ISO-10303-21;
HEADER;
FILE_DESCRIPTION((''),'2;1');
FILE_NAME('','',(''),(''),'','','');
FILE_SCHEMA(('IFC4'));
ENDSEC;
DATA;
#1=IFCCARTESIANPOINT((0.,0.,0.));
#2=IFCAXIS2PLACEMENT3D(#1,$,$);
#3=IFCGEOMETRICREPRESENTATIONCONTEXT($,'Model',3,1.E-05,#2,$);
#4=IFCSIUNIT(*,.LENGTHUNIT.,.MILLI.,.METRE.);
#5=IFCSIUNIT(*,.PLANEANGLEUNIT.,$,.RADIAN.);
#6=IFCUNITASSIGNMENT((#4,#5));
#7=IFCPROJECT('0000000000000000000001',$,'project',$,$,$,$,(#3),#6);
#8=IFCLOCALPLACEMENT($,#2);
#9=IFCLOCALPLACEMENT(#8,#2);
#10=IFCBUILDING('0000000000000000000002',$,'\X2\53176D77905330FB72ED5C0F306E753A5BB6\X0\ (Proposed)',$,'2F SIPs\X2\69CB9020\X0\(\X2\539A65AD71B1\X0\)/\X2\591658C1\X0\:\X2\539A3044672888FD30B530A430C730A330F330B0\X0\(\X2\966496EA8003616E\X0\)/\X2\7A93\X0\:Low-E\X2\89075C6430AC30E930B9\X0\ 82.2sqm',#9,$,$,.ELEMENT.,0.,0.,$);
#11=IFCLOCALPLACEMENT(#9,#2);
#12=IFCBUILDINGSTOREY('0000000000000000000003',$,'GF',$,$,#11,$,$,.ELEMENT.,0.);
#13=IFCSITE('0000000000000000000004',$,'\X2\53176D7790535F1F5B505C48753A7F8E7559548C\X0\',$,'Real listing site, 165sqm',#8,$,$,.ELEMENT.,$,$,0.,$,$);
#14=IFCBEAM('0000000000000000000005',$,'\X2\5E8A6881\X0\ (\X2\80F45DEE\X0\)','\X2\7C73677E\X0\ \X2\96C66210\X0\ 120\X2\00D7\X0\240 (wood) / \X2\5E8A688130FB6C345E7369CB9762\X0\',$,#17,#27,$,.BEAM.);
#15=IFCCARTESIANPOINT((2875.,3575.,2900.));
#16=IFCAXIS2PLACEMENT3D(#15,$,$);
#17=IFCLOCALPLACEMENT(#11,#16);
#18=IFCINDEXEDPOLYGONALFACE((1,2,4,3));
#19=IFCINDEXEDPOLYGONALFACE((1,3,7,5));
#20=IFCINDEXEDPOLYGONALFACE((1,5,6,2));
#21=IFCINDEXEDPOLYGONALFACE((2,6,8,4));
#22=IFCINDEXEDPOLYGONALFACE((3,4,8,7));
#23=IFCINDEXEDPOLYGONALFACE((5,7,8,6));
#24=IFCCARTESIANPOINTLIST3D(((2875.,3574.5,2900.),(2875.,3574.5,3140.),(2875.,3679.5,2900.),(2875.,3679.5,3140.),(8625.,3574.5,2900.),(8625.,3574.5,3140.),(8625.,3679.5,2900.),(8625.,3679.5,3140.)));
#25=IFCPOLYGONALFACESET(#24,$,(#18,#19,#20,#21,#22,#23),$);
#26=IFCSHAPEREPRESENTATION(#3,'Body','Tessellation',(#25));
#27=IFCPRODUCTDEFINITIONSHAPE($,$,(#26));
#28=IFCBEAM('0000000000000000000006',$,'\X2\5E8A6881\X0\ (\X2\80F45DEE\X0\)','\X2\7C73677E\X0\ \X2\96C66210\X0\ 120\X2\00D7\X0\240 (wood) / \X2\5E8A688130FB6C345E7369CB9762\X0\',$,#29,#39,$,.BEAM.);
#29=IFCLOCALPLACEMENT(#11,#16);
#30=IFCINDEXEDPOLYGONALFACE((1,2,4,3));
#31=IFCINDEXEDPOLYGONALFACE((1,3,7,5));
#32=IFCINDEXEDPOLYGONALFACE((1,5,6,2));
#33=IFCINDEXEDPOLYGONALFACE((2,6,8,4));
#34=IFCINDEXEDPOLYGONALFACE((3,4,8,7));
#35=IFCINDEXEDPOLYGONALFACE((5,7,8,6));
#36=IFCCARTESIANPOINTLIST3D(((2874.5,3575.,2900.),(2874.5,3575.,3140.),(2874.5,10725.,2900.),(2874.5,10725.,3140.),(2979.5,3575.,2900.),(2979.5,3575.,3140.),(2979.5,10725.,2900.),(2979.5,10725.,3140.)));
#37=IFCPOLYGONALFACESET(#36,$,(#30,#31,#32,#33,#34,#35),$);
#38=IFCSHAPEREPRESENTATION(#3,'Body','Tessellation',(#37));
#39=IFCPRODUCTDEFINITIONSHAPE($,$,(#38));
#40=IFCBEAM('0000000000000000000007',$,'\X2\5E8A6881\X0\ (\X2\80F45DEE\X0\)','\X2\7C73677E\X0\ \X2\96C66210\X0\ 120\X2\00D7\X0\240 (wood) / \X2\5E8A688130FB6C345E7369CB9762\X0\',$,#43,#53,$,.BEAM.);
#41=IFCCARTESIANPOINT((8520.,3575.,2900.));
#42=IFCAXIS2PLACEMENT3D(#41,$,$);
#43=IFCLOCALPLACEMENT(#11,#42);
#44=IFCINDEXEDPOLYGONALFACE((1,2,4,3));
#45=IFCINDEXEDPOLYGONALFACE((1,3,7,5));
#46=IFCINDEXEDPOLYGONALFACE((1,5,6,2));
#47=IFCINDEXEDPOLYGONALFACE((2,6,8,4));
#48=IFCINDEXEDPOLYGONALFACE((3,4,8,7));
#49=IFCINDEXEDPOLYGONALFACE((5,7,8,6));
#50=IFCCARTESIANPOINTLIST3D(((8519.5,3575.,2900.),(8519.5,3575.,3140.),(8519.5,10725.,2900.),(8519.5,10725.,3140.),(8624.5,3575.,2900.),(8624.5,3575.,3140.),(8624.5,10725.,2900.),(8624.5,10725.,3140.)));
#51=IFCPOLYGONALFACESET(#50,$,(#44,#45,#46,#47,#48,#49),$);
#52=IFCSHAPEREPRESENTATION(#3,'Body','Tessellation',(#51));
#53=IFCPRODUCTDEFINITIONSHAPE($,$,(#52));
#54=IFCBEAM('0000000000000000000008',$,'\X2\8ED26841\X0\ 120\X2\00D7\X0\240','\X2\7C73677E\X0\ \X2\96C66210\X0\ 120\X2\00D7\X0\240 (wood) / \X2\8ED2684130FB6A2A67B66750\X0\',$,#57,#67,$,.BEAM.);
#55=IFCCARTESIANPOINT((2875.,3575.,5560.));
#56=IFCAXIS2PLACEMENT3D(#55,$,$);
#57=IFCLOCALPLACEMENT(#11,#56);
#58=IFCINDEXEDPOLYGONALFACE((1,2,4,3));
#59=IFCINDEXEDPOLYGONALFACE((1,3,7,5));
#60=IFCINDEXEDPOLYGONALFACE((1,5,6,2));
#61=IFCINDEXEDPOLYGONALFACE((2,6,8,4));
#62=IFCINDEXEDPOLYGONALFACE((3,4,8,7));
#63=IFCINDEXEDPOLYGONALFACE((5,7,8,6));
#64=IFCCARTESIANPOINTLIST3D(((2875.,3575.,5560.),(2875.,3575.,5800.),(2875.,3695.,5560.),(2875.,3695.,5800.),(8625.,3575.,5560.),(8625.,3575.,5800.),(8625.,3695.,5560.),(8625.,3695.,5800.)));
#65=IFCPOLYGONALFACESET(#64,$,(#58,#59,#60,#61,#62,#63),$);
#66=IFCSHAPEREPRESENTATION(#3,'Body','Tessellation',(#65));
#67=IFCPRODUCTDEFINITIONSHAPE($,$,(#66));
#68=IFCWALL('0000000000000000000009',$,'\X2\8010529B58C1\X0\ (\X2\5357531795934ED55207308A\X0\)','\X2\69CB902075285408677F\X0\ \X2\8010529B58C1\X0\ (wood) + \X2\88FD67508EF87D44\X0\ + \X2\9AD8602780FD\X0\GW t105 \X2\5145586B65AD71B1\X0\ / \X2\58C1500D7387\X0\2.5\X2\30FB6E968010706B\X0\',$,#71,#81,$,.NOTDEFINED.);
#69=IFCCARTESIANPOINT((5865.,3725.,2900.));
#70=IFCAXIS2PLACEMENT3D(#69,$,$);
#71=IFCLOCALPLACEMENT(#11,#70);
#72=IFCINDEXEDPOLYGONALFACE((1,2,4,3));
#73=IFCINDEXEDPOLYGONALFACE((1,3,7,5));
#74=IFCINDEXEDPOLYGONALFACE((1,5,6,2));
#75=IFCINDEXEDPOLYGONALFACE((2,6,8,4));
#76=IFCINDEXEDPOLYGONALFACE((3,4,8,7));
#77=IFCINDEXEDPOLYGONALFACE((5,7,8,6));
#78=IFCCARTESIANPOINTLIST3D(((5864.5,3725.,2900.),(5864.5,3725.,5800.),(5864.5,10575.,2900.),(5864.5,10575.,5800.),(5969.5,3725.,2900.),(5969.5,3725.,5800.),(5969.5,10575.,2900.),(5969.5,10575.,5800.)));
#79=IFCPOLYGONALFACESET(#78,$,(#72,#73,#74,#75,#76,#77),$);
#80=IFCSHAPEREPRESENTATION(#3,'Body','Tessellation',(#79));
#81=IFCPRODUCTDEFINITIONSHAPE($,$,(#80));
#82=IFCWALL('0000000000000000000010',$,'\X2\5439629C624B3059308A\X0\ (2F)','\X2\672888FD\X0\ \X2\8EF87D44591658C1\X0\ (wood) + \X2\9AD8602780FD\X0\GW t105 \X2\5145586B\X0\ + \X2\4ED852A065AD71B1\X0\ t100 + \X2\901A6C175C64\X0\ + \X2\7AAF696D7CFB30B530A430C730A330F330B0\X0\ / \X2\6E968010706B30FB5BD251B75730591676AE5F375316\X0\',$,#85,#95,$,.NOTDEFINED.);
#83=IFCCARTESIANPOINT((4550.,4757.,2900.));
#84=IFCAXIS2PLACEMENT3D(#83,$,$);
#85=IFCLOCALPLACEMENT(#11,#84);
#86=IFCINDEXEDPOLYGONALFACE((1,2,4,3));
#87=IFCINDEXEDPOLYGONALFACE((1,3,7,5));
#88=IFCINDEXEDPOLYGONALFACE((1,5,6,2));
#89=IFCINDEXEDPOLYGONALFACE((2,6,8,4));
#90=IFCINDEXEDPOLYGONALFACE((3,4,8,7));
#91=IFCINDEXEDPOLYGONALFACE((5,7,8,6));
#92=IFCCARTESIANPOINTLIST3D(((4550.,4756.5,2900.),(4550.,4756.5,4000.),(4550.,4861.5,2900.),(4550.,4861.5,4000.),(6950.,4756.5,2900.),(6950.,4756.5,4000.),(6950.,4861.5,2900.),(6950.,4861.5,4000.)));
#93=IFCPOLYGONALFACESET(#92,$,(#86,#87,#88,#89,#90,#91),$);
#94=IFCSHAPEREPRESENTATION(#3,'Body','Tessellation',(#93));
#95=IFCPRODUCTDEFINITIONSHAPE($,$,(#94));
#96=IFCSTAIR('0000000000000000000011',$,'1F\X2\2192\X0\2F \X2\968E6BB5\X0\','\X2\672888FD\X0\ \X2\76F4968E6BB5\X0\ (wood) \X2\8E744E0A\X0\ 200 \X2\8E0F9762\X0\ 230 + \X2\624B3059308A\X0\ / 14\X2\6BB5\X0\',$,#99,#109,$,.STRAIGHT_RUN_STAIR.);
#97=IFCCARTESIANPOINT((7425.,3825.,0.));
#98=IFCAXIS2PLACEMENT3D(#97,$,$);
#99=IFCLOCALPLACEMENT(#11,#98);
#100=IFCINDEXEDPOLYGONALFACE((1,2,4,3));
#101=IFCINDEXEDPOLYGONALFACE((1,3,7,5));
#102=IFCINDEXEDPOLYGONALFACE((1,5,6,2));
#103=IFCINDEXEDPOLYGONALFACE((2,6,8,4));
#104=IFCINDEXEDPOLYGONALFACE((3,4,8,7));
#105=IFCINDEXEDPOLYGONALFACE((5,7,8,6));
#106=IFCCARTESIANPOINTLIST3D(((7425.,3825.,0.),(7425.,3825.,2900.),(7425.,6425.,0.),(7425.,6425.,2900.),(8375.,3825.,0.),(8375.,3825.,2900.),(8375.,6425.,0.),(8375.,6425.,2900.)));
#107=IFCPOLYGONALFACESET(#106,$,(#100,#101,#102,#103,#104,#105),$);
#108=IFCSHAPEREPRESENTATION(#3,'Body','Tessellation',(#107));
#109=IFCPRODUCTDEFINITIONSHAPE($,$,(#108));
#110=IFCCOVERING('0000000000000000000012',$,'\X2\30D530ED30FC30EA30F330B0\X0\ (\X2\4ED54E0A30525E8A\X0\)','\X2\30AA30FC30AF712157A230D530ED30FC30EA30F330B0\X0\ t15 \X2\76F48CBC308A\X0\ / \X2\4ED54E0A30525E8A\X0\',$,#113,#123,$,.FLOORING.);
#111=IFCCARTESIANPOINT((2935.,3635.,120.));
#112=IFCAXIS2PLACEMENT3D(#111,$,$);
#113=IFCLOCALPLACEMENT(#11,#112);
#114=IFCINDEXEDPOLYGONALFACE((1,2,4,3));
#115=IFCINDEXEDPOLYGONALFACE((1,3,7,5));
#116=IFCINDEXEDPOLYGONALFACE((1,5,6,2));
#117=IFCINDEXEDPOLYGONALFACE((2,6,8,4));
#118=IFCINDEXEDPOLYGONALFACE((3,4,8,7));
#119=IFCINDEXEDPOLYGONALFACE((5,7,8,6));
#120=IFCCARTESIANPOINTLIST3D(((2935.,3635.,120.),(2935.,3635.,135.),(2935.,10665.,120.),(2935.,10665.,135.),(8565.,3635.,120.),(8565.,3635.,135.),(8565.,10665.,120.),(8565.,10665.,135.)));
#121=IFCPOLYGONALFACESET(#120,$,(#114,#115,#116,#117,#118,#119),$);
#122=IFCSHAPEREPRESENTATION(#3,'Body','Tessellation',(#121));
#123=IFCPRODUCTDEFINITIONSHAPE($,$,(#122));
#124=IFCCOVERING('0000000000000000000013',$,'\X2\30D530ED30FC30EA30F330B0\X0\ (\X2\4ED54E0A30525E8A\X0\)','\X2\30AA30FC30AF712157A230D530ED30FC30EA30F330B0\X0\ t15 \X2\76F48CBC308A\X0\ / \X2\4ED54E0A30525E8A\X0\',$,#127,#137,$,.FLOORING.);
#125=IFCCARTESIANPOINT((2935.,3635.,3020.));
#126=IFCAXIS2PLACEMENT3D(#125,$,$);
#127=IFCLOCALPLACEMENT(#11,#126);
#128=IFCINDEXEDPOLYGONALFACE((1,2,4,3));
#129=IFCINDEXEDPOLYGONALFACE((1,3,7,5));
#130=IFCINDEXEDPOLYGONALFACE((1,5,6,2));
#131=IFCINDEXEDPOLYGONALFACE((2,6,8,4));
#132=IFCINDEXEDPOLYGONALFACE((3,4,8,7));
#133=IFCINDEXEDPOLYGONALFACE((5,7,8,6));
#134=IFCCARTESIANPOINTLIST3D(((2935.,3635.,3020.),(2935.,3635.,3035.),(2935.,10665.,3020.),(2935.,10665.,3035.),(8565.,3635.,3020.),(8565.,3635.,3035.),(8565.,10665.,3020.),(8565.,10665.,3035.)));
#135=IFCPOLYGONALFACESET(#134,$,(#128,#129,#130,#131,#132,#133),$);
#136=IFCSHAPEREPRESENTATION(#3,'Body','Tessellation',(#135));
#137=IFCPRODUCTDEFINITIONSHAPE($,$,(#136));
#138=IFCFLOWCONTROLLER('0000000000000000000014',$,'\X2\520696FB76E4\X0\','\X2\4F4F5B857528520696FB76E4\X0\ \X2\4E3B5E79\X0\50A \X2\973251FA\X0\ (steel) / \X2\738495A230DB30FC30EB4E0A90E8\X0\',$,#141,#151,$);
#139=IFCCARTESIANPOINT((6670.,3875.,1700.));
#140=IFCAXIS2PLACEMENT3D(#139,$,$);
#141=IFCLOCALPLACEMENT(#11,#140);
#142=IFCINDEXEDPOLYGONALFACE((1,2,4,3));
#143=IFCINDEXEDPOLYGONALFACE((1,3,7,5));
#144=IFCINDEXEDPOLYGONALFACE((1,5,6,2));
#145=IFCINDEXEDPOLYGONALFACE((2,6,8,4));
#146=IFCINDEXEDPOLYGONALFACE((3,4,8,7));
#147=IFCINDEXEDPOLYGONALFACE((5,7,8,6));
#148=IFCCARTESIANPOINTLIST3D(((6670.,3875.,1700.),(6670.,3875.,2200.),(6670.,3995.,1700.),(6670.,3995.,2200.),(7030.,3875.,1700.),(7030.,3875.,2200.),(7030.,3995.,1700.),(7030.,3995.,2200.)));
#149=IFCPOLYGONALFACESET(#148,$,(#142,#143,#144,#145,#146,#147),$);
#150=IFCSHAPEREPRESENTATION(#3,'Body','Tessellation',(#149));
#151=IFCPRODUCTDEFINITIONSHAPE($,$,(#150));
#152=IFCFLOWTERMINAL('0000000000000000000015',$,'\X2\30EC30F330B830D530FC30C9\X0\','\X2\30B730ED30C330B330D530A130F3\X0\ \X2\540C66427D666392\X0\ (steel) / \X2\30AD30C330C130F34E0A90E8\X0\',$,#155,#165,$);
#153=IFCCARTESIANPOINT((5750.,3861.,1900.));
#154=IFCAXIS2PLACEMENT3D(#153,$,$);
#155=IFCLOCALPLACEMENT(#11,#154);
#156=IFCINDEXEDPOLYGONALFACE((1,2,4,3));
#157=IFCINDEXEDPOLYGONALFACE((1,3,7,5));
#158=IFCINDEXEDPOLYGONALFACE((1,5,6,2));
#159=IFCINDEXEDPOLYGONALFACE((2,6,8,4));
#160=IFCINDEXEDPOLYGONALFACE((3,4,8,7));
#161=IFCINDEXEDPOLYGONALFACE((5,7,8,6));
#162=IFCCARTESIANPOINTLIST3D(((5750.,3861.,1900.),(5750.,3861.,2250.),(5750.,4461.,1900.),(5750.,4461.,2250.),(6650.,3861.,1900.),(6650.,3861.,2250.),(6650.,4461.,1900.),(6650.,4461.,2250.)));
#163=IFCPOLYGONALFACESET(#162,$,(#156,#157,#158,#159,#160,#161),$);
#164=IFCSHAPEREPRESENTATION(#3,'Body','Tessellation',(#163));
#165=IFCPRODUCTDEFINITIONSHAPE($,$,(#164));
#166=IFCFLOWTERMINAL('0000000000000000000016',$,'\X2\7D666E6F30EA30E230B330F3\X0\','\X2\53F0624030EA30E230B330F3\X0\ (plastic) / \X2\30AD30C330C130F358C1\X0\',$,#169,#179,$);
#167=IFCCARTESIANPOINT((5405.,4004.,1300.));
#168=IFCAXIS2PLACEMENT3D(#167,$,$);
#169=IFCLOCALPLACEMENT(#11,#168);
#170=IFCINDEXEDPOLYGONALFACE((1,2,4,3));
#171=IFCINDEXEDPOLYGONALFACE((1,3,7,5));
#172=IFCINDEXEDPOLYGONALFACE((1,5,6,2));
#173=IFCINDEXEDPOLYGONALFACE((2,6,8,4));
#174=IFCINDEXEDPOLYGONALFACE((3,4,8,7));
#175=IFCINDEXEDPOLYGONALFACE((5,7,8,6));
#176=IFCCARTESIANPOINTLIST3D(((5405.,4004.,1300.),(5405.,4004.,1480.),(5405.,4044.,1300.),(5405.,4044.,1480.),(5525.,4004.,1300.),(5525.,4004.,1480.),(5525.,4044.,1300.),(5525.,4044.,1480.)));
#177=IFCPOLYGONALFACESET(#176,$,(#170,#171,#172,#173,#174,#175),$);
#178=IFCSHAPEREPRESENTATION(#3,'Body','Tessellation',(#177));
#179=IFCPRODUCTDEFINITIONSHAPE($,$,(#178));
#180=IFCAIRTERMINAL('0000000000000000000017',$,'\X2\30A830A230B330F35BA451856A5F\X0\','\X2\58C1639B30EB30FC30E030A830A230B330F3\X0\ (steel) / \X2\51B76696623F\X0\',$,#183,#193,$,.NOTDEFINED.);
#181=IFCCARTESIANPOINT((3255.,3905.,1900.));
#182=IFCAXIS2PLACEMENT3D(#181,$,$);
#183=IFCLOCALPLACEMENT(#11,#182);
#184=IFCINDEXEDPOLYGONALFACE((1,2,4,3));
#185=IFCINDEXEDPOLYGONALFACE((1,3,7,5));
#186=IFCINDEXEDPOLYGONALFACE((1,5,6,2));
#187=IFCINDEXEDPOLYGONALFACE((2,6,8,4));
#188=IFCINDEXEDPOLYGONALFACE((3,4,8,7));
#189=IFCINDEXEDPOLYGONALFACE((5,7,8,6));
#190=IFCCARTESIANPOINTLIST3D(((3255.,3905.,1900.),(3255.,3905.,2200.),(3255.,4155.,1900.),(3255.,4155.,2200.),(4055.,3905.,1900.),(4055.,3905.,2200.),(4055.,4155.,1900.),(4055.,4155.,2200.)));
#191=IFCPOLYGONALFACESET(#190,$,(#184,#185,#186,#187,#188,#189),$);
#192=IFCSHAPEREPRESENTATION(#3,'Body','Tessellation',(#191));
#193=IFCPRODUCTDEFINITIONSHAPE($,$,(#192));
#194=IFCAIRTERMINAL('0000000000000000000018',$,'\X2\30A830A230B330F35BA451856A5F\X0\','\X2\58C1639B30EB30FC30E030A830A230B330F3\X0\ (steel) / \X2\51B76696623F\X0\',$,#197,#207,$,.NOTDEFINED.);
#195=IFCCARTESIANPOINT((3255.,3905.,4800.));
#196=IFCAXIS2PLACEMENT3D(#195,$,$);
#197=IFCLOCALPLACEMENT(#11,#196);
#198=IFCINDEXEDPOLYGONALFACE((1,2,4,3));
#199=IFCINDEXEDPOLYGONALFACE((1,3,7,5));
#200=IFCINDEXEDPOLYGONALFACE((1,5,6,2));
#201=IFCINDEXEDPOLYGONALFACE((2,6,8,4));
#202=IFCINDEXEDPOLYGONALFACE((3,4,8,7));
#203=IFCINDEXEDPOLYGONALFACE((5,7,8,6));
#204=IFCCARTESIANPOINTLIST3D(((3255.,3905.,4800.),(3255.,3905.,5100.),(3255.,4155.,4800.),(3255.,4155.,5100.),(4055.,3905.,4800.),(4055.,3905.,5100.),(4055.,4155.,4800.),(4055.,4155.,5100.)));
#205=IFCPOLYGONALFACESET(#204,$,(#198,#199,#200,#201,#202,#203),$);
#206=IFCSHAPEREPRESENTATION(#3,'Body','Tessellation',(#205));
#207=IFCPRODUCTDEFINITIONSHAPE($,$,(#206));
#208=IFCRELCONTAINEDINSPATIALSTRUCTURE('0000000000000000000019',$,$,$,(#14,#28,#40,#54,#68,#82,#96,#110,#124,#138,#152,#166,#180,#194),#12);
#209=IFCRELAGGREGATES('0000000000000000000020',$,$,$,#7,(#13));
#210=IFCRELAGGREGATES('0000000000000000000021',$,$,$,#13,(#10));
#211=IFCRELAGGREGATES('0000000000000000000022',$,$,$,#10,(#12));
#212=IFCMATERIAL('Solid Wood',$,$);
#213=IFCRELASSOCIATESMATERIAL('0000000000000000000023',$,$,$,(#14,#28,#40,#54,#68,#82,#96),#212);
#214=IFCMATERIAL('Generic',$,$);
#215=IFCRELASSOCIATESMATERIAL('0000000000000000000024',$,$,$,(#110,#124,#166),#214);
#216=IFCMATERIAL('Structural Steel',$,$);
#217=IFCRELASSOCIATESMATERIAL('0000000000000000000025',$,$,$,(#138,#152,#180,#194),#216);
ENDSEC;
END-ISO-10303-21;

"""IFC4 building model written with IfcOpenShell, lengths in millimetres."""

from ifc_helpers import new_model, si_unit, frame, frame_2d, origin, place, context, project, spatial, rectangle, extrude, material, element, save


model = new_model("IFC4")

# Units and contexts
model_context = context("Model", 3, precision=1e-05, world=origin())
ifc_project = project(units=[si_unit("LENGTHUNIT", "METRE", prefix="MILLI"), si_unit("PLANEANGLEUNIT", "RADIAN")], contexts=[model_context])

# Site, building, storey
site_placement = place(None, origin())
site = spatial("IfcSite", under=ifc_project, at=site_placement, Name="北海道弟子屈町美留和", ObjectType="Real listing site, 165sqm", CompositionType="ELEMENT", RefElevation=0.0)
building_placement = place(site_placement, origin())
building = spatial("IfcBuilding", under=site, at=building_placement, Name="北海道・狭小の町家 (Proposed)", ObjectType="2F SIPs構造(厚断熱)/外壁:厚い木製サイディング(除雪考慮)/窓:Low-E複層ガラス 82.2sqm", CompositionType="ELEMENT", ElevationOfRefHeight=0.0, ElevationOfTerrain=0.0)
storey_placement = place(building_placement, origin())
storey = spatial("IfcBuildingStorey", under=building, at=storey_placement, Name="GF", CompositionType="ELEMENT", Elevation=0.0)

# Shared definitions
ifc_material_1 = material(Name="Solid Wood")

# Beams
beam_1_placement = place(storey_placement, frame((2875.0, 3575.0, 2900.0)))
element("IfcBeam", 1, at=beam_1_placement, inside=storey, material=ifc_material_1, Name="床梁 (胴差)", Description="米松 集成 120×240 (wood) / 床梁・水平構面", PredefinedType="BEAM", context=model_context, shape_type="SweptSolid", body=[
    extrude(rectangle(XDim=5750.0, YDim=105.0, at=frame_2d((2875.0, 52.0))), frame((2875.0, 3575.0, 2900.0)), (0.0, 0.0, 1.0), 240.0),
])
beam_2_placement = place(storey_placement, frame((2875.0, 3575.0, 2900.0)))
element("IfcBeam", 2, at=beam_2_placement, inside=storey, material=ifc_material_1, Name="床梁 (胴差)", Description="米松 集成 120×240 (wood) / 床梁・水平構面", PredefinedType="BEAM", context=model_context, shape_type="SweptSolid", body=[
    extrude(rectangle(XDim=105.0, YDim=7150.0, at=frame_2d((52.0, 3575.0))), frame((2875.0, 3575.0, 2900.0)), (0.0, 0.0, 1.0), 240.0),
])
beam_3_placement = place(storey_placement, frame((8520.0, 3575.0, 2900.0)))
element("IfcBeam", 3, at=beam_3_placement, inside=storey, material=ifc_material_1, Name="床梁 (胴差)", Description="米松 集成 120×240 (wood) / 床梁・水平構面", PredefinedType="BEAM", context=model_context, shape_type="SweptSolid", body=[
    extrude(rectangle(XDim=105.0, YDim=7150.0, at=frame_2d((52.0, 3575.0))), frame((8520.0, 3575.0, 2900.0)), (0.0, 0.0, 1.0), 240.0),
])
beam_4_placement = place(storey_placement, frame((2875.0, 3575.0, 5560.0)))
element("IfcBeam", 4, at=beam_4_placement, inside=storey, material=ifc_material_1, Name="軒桁 120×240", Description="米松 集成 120×240 (wood) / 軒桁・横架材", PredefinedType="BEAM", context=model_context, shape_type="SweptSolid", body=[
    extrude(rectangle(XDim=5750.0, YDim=120.0, at=frame_2d((2875.0, 60.0))), frame((2875.0, 3575.0, 5560.0)), (0.0, 0.0, 1.0), 240.0),
])

# Walls
wall_1_placement = place(storey_placement, frame((5865.0, 3725.0, 2900.0)))
element("IfcWall", 5, at=wall_1_placement, inside=storey, material=ifc_material_1, Name="耐力壁 (南北間仕切り)", Description="構造用合板 耐力壁 (wood) + 製材軸組 + 高性能GW t105 充填断熱 / 壁倍率2.5・準耐火", PredefinedType="NOTDEFINED", context=model_context, shape_type="SweptSolid", body=[
    extrude(rectangle(XDim=105.0, YDim=6850.0, at=frame_2d((52.0, 3425.0))), frame((5865.0, 3725.0, 2900.0)), (0.0, 0.0, 1.0), 2900.0),
])
wall_2_placement = place(storey_placement, frame((4550.0, 4757.0, 2900.0)))
element("IfcWall", 6, at=wall_2_placement, inside=storey, material=ifc_material_1, Name="吹抜手すり (2F)", Description="木製 軸組外壁 (wood) + 高性能GW t105 充填 + 付加断熱 t100 + 通気層 + 窯業系サイディング / 準耐火・寒冷地外皮強化", PredefinedType="NOTDEFINED", context=model_context, shape_type="SweptSolid", body=[
    extrude(rectangle(XDim=2400.0, YDim=105.0, at=frame_2d((1200.0, 52.0))), frame((4550.0, 4757.0, 2900.0)), (0.0, 0.0, 1.0), 1100.0),
])

# Stair
stair_placement = place(storey_placement, frame((7425.0, 3825.0, 0.0)))
element("IfcStair", 7, at=stair_placement, inside=storey, material=ifc_material_1, Name="1F→2F 階段", Description="木製 直階段 (wood) 蹴上 200 踏面 230 + 手すり / 14段", PredefinedType="STRAIGHT_RUN_STAIR", context=model_context, shape_type="SweptSolid", body=[
    extrude(rectangle(XDim=950.0, YDim=2600.0, at=frame_2d((475.0, 1300.0))), frame((7425.0, 3825.0, 0.0)), (0.0, 0.0, 1.0), 2900.0),
])

# Coverings
ifc_material_2 = material(Name="Generic")
covering_1_placement = place(storey_placement, frame((2935.0, 3635.0, 120.0)))
element("IfcCovering", 8, at=covering_1_placement, inside=storey, material=ifc_material_2, Name="フローリング (仕上げ床)", Description="オーク無垢フローリング t15 直貼り / 仕上げ床", PredefinedType="FLOORING", context=model_context, shape_type="SweptSolid", body=[
    extrude(rectangle(XDim=5630.0, YDim=7030.0, at=frame_2d((2815.0, 3515.0))), frame((2935.0, 3635.0, 120.0)), (0.0, 0.0, 1.0), 15.0),
])
covering_2_placement = place(storey_placement, frame((2935.0, 3635.0, 3020.0)))
element("IfcCovering", 9, at=covering_2_placement, inside=storey, material=ifc_material_2, Name="フローリング (仕上げ床)", Description="オーク無垢フローリング t15 直貼り / 仕上げ床", PredefinedType="FLOORING", context=model_context, shape_type="SweptSolid", body=[
    extrude(rectangle(XDim=5630.0, YDim=7030.0, at=frame_2d((2815.0, 3515.0))), frame((2935.0, 3635.0, 3020.0)), (0.0, 0.0, 1.0), 15.0),
])

# Flow controller
ifc_material_3 = material(Name="Structural Steel")
flow_controller_placement = place(storey_placement, frame((6670.0, 3875.0, 1700.0)))
element("IfcFlowController", 10, at=flow_controller_placement, inside=storey, material=ifc_material_3, Name="分電盤", Description="住宅用分電盤 主幹50A 露出 (steel) / 玄関ホール上部", context=model_context, shape_type="SweptSolid", body=[
    extrude(rectangle(XDim=360.0, YDim=120.0, at=frame_2d((180.0, 60.0))), frame((6670.0, 3875.0, 1700.0)), (0.0, 0.0, 1.0), 500.0),
])

# Flow terminals
flow_terminal_1_placement = place(storey_placement, frame((5750.0, 3861.0, 1900.0)))
element("IfcFlowTerminal", 11, at=flow_terminal_1_placement, inside=storey, material=ifc_material_3, Name="レンジフード", Description="シロッコファン 同時給排 (steel) / キッチン上部", context=model_context, shape_type="SweptSolid", body=[
    extrude(rectangle(XDim=900.0, YDim=600.0, at=frame_2d((450.0, 300.0))), frame((5750.0, 3861.0, 1900.0)), (0.0, 0.0, 1.0), 350.0),
])
flow_terminal_2_placement = place(storey_placement, frame((5405.0, 4004.0, 1300.0)))
element("IfcFlowTerminal", 12, at=flow_terminal_2_placement, inside=storey, material=ifc_material_2, Name="給湯リモコン", Description="台所リモコン (plastic) / キッチン壁", context=model_context, shape_type="SweptSolid", body=[
    extrude(rectangle(XDim=120.0, YDim=40.0, at=frame_2d((60.0, 20.0))), frame((5405.0, 4004.0, 1300.0)), (0.0, 0.0, 1.0), 180.0),
])

# Air terminals
air_terminal_1_placement = place(storey_placement, frame((3255.0, 3905.0, 1900.0)))
element("IfcAirTerminal", 13, at=air_terminal_1_placement, inside=storey, material=ifc_material_3, Name="エアコン室内機", Description="壁掛ルームエアコン (steel) / 冷暖房", PredefinedType="NOTDEFINED", context=model_context, shape_type="SweptSolid", body=[
    extrude(rectangle(XDim=800.0, YDim=250.0, at=frame_2d((400.0, 125.0))), frame((3255.0, 3905.0, 1900.0)), (0.0, 0.0, 1.0), 300.0),
])
air_terminal_2_placement = place(storey_placement, frame((3255.0, 3905.0, 4800.0)))
element("IfcAirTerminal", 14, at=air_terminal_2_placement, inside=storey, material=ifc_material_3, Name="エアコン室内機", Description="壁掛ルームエアコン (steel) / 冷暖房", PredefinedType="NOTDEFINED", context=model_context, shape_type="SweptSolid", body=[
    extrude(rectangle(XDim=800.0, YDim=250.0, at=frame_2d((400.0, 125.0))), frame((3255.0, 3905.0, 4800.0)), (0.0, 0.0, 1.0), 300.0),
])

save(model, "model.ifc")
